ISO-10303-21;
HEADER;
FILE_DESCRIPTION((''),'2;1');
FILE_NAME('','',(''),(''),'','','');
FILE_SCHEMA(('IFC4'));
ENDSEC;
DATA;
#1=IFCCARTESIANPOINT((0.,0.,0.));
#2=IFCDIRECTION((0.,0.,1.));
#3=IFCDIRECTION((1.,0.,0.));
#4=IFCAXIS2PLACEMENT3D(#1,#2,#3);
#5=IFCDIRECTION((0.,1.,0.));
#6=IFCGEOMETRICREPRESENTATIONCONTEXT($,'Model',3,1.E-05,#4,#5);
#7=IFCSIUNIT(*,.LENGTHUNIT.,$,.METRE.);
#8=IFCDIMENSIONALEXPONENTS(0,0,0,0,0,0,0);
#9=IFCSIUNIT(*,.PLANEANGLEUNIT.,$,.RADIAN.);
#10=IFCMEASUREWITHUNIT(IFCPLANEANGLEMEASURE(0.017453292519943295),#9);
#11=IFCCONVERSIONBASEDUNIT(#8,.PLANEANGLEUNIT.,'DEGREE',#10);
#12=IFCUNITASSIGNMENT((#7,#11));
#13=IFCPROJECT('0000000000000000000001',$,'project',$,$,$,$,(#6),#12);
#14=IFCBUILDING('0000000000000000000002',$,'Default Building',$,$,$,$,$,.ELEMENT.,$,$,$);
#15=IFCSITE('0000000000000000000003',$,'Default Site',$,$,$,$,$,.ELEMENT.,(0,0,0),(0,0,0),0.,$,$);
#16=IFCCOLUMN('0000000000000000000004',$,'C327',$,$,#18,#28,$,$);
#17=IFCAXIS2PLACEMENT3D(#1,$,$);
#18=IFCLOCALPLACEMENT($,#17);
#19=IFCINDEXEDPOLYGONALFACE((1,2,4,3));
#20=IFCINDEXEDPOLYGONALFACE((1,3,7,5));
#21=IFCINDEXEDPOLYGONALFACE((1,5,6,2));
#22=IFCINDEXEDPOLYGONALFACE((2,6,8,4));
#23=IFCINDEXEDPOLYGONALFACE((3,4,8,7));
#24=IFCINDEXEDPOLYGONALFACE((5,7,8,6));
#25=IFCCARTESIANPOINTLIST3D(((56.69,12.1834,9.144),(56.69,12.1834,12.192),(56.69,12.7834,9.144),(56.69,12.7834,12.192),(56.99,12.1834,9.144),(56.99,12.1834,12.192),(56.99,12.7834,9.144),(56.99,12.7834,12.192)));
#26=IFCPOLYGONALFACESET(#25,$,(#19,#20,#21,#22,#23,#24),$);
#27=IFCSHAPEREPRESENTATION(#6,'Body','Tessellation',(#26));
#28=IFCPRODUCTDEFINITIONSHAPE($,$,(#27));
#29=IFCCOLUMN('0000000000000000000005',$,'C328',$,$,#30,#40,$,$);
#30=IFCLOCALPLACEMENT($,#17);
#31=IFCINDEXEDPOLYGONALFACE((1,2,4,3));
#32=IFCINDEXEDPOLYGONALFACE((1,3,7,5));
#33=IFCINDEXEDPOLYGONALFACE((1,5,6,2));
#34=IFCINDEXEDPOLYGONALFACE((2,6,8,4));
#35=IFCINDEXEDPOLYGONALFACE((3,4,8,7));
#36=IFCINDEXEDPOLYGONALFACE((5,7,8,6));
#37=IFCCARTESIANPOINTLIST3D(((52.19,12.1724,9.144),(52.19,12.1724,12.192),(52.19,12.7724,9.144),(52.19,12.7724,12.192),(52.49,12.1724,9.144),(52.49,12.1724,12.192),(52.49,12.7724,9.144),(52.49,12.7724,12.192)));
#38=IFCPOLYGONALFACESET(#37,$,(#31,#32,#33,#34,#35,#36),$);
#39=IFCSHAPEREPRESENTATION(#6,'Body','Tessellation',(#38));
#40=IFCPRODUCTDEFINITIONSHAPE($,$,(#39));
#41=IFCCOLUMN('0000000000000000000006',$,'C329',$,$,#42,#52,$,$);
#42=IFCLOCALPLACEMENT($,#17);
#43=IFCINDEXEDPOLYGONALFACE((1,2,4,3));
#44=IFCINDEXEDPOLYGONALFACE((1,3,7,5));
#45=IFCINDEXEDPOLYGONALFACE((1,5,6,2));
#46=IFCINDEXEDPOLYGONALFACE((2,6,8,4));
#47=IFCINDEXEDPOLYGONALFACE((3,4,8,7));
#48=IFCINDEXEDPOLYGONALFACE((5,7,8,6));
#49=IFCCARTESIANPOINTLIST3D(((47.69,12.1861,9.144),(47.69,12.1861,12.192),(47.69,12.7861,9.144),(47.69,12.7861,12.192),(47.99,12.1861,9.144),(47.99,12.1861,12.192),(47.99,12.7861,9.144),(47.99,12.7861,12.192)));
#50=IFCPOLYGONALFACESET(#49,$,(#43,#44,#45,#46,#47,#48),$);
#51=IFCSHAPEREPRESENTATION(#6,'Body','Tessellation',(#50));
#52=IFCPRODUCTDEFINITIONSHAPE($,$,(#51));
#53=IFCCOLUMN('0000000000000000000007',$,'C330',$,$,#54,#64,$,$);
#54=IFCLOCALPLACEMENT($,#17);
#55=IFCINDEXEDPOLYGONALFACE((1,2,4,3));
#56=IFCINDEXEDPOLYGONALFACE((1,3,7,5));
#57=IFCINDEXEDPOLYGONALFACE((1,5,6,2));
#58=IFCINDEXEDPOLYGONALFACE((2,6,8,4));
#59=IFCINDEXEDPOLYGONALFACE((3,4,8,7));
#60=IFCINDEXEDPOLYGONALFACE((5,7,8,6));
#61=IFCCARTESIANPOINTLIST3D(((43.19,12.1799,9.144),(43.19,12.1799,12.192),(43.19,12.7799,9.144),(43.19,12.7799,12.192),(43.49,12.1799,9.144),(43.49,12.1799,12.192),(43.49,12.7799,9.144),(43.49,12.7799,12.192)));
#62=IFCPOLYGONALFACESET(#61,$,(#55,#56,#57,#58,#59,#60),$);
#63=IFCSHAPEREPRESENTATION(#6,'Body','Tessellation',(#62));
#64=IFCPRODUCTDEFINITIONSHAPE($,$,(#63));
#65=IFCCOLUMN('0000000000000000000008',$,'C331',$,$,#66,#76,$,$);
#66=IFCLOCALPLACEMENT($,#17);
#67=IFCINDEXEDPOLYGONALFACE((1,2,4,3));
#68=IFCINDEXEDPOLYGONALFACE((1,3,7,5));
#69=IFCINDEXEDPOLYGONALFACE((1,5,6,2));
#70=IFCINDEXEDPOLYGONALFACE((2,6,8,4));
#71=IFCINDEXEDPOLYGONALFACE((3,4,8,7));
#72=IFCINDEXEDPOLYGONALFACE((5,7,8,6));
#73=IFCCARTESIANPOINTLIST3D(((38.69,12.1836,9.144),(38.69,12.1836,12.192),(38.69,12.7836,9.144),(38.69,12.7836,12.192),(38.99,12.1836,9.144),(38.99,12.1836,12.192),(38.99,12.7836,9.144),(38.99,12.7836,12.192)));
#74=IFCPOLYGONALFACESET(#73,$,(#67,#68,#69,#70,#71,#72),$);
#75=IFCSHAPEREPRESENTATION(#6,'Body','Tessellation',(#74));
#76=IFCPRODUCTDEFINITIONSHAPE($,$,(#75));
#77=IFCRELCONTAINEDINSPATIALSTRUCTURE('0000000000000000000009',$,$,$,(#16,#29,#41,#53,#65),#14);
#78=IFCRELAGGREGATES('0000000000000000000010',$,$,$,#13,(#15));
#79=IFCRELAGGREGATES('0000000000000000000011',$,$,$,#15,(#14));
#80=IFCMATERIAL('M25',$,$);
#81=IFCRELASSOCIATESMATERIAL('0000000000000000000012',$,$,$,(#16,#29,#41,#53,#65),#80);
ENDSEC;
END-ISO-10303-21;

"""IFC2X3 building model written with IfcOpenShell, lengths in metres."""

from ifc_helpers import new_model, entity, si_unit, converted_unit, direction, frame, frame_2d, origin_with_axes, place, context, project, spatial, rectangle, extrude, material, element, save


model = new_model("IFC2X3")

# Units and contexts
model_context = context("Model", 3, precision=1e-05, world=origin_with_axes(), true_north=direction((0.0, 1.0, 0.0)))
ifc_project = project(units=[si_unit("LENGTHUNIT", "METRE"), converted_unit("PLANEANGLEUNIT", "DEGREE", entity("IfcPlaneAngleMeasure", 0.017453292519943295), si_unit("PLANEANGLEUNIT", "RADIAN"), dimensions=[0, 0, 0, 0, 0, 0, 0])], contexts=[model_context])

# Site, building
site = spatial("IfcSite", under=ifc_project, Name="Default Site", CompositionType="ELEMENT", RefLatitude=(0, 0, 0), RefLongitude=(0, 0, 0), RefElevation=0.0)
building = spatial("IfcBuilding", under=site, Name="Default Building", CompositionType="ELEMENT")

# Columns
ifc_material = material(Name="M25")
placement = place(None, origin_with_axes())
element("IfcColumn", 1, at=placement, inside=building, material=ifc_material, Name="C327", context=model_context, shape_type="SweptSolid", body=[
    extrude(rectangle(XDim=0.3, YDim=0.6, at=frame_2d((0.0, 0.0), x_axis=(1.0, 0.0, 0.0))), frame((56.84, 12.4834, 9.144), z_axis=(0.0, 0.0, 1.0), x_axis=(1.0, 0.0, 0.0)), (0.0, 0.0, 1.0), 3.048),
])
element("IfcColumn", 2, at=placement, inside=building, material=ifc_material, Name="C328", context=model_context, shape_type="SweptSolid", body=[
    extrude(rectangle(XDim=0.3, YDim=0.6, at=frame_2d((0.0, 0.0), x_axis=(1.0, 0.0, 0.0))), frame((52.34, 12.4724, 9.144), z_axis=(0.0, 0.0, 1.0), x_axis=(1.0, 0.0, 0.0)), (0.0, 0.0, 1.0), 3.048),
])
element("IfcColumn", 3, at=placement, inside=building, material=ifc_material, Name="C329", context=model_context, shape_type="SweptSolid", body=[
    extrude(rectangle(XDim=0.3, YDim=0.6, at=frame_2d((0.0, 0.0), x_axis=(1.0, 0.0, 0.0))), frame((47.84, 12.4861, 9.144), z_axis=(0.0, 0.0, 1.0), x_axis=(1.0, 0.0, 0.0)), (0.0, 0.0, 1.0), 3.048),
])
element("IfcColumn", 4, at=placement, inside=building, material=ifc_material, Name="C330", context=model_context, shape_type="SweptSolid", body=[
    extrude(rectangle(XDim=0.3, YDim=0.6, at=frame_2d((0.0, 0.0), x_axis=(1.0, 0.0, 0.0))), frame((43.34, 12.4799, 9.144), z_axis=(0.0, 0.0, 1.0), x_axis=(1.0, 0.0, 0.0)), (0.0, 0.0, 1.0), 3.048),
])
element("IfcColumn", 5, at=placement, inside=building, material=ifc_material, Name="C331", context=model_context, shape_type="SweptSolid", body=[
    extrude(rectangle(XDim=0.3, YDim=0.6, at=frame_2d((0.0, 0.0), x_axis=(1.0, 0.0, 0.0))), frame((38.84, 12.4836, 9.144), z_axis=(0.0, 0.0, 1.0), x_axis=(1.0, 0.0, 0.0)), (0.0, 0.0, 1.0), 3.048),
])

save(model, "model.ifc")
